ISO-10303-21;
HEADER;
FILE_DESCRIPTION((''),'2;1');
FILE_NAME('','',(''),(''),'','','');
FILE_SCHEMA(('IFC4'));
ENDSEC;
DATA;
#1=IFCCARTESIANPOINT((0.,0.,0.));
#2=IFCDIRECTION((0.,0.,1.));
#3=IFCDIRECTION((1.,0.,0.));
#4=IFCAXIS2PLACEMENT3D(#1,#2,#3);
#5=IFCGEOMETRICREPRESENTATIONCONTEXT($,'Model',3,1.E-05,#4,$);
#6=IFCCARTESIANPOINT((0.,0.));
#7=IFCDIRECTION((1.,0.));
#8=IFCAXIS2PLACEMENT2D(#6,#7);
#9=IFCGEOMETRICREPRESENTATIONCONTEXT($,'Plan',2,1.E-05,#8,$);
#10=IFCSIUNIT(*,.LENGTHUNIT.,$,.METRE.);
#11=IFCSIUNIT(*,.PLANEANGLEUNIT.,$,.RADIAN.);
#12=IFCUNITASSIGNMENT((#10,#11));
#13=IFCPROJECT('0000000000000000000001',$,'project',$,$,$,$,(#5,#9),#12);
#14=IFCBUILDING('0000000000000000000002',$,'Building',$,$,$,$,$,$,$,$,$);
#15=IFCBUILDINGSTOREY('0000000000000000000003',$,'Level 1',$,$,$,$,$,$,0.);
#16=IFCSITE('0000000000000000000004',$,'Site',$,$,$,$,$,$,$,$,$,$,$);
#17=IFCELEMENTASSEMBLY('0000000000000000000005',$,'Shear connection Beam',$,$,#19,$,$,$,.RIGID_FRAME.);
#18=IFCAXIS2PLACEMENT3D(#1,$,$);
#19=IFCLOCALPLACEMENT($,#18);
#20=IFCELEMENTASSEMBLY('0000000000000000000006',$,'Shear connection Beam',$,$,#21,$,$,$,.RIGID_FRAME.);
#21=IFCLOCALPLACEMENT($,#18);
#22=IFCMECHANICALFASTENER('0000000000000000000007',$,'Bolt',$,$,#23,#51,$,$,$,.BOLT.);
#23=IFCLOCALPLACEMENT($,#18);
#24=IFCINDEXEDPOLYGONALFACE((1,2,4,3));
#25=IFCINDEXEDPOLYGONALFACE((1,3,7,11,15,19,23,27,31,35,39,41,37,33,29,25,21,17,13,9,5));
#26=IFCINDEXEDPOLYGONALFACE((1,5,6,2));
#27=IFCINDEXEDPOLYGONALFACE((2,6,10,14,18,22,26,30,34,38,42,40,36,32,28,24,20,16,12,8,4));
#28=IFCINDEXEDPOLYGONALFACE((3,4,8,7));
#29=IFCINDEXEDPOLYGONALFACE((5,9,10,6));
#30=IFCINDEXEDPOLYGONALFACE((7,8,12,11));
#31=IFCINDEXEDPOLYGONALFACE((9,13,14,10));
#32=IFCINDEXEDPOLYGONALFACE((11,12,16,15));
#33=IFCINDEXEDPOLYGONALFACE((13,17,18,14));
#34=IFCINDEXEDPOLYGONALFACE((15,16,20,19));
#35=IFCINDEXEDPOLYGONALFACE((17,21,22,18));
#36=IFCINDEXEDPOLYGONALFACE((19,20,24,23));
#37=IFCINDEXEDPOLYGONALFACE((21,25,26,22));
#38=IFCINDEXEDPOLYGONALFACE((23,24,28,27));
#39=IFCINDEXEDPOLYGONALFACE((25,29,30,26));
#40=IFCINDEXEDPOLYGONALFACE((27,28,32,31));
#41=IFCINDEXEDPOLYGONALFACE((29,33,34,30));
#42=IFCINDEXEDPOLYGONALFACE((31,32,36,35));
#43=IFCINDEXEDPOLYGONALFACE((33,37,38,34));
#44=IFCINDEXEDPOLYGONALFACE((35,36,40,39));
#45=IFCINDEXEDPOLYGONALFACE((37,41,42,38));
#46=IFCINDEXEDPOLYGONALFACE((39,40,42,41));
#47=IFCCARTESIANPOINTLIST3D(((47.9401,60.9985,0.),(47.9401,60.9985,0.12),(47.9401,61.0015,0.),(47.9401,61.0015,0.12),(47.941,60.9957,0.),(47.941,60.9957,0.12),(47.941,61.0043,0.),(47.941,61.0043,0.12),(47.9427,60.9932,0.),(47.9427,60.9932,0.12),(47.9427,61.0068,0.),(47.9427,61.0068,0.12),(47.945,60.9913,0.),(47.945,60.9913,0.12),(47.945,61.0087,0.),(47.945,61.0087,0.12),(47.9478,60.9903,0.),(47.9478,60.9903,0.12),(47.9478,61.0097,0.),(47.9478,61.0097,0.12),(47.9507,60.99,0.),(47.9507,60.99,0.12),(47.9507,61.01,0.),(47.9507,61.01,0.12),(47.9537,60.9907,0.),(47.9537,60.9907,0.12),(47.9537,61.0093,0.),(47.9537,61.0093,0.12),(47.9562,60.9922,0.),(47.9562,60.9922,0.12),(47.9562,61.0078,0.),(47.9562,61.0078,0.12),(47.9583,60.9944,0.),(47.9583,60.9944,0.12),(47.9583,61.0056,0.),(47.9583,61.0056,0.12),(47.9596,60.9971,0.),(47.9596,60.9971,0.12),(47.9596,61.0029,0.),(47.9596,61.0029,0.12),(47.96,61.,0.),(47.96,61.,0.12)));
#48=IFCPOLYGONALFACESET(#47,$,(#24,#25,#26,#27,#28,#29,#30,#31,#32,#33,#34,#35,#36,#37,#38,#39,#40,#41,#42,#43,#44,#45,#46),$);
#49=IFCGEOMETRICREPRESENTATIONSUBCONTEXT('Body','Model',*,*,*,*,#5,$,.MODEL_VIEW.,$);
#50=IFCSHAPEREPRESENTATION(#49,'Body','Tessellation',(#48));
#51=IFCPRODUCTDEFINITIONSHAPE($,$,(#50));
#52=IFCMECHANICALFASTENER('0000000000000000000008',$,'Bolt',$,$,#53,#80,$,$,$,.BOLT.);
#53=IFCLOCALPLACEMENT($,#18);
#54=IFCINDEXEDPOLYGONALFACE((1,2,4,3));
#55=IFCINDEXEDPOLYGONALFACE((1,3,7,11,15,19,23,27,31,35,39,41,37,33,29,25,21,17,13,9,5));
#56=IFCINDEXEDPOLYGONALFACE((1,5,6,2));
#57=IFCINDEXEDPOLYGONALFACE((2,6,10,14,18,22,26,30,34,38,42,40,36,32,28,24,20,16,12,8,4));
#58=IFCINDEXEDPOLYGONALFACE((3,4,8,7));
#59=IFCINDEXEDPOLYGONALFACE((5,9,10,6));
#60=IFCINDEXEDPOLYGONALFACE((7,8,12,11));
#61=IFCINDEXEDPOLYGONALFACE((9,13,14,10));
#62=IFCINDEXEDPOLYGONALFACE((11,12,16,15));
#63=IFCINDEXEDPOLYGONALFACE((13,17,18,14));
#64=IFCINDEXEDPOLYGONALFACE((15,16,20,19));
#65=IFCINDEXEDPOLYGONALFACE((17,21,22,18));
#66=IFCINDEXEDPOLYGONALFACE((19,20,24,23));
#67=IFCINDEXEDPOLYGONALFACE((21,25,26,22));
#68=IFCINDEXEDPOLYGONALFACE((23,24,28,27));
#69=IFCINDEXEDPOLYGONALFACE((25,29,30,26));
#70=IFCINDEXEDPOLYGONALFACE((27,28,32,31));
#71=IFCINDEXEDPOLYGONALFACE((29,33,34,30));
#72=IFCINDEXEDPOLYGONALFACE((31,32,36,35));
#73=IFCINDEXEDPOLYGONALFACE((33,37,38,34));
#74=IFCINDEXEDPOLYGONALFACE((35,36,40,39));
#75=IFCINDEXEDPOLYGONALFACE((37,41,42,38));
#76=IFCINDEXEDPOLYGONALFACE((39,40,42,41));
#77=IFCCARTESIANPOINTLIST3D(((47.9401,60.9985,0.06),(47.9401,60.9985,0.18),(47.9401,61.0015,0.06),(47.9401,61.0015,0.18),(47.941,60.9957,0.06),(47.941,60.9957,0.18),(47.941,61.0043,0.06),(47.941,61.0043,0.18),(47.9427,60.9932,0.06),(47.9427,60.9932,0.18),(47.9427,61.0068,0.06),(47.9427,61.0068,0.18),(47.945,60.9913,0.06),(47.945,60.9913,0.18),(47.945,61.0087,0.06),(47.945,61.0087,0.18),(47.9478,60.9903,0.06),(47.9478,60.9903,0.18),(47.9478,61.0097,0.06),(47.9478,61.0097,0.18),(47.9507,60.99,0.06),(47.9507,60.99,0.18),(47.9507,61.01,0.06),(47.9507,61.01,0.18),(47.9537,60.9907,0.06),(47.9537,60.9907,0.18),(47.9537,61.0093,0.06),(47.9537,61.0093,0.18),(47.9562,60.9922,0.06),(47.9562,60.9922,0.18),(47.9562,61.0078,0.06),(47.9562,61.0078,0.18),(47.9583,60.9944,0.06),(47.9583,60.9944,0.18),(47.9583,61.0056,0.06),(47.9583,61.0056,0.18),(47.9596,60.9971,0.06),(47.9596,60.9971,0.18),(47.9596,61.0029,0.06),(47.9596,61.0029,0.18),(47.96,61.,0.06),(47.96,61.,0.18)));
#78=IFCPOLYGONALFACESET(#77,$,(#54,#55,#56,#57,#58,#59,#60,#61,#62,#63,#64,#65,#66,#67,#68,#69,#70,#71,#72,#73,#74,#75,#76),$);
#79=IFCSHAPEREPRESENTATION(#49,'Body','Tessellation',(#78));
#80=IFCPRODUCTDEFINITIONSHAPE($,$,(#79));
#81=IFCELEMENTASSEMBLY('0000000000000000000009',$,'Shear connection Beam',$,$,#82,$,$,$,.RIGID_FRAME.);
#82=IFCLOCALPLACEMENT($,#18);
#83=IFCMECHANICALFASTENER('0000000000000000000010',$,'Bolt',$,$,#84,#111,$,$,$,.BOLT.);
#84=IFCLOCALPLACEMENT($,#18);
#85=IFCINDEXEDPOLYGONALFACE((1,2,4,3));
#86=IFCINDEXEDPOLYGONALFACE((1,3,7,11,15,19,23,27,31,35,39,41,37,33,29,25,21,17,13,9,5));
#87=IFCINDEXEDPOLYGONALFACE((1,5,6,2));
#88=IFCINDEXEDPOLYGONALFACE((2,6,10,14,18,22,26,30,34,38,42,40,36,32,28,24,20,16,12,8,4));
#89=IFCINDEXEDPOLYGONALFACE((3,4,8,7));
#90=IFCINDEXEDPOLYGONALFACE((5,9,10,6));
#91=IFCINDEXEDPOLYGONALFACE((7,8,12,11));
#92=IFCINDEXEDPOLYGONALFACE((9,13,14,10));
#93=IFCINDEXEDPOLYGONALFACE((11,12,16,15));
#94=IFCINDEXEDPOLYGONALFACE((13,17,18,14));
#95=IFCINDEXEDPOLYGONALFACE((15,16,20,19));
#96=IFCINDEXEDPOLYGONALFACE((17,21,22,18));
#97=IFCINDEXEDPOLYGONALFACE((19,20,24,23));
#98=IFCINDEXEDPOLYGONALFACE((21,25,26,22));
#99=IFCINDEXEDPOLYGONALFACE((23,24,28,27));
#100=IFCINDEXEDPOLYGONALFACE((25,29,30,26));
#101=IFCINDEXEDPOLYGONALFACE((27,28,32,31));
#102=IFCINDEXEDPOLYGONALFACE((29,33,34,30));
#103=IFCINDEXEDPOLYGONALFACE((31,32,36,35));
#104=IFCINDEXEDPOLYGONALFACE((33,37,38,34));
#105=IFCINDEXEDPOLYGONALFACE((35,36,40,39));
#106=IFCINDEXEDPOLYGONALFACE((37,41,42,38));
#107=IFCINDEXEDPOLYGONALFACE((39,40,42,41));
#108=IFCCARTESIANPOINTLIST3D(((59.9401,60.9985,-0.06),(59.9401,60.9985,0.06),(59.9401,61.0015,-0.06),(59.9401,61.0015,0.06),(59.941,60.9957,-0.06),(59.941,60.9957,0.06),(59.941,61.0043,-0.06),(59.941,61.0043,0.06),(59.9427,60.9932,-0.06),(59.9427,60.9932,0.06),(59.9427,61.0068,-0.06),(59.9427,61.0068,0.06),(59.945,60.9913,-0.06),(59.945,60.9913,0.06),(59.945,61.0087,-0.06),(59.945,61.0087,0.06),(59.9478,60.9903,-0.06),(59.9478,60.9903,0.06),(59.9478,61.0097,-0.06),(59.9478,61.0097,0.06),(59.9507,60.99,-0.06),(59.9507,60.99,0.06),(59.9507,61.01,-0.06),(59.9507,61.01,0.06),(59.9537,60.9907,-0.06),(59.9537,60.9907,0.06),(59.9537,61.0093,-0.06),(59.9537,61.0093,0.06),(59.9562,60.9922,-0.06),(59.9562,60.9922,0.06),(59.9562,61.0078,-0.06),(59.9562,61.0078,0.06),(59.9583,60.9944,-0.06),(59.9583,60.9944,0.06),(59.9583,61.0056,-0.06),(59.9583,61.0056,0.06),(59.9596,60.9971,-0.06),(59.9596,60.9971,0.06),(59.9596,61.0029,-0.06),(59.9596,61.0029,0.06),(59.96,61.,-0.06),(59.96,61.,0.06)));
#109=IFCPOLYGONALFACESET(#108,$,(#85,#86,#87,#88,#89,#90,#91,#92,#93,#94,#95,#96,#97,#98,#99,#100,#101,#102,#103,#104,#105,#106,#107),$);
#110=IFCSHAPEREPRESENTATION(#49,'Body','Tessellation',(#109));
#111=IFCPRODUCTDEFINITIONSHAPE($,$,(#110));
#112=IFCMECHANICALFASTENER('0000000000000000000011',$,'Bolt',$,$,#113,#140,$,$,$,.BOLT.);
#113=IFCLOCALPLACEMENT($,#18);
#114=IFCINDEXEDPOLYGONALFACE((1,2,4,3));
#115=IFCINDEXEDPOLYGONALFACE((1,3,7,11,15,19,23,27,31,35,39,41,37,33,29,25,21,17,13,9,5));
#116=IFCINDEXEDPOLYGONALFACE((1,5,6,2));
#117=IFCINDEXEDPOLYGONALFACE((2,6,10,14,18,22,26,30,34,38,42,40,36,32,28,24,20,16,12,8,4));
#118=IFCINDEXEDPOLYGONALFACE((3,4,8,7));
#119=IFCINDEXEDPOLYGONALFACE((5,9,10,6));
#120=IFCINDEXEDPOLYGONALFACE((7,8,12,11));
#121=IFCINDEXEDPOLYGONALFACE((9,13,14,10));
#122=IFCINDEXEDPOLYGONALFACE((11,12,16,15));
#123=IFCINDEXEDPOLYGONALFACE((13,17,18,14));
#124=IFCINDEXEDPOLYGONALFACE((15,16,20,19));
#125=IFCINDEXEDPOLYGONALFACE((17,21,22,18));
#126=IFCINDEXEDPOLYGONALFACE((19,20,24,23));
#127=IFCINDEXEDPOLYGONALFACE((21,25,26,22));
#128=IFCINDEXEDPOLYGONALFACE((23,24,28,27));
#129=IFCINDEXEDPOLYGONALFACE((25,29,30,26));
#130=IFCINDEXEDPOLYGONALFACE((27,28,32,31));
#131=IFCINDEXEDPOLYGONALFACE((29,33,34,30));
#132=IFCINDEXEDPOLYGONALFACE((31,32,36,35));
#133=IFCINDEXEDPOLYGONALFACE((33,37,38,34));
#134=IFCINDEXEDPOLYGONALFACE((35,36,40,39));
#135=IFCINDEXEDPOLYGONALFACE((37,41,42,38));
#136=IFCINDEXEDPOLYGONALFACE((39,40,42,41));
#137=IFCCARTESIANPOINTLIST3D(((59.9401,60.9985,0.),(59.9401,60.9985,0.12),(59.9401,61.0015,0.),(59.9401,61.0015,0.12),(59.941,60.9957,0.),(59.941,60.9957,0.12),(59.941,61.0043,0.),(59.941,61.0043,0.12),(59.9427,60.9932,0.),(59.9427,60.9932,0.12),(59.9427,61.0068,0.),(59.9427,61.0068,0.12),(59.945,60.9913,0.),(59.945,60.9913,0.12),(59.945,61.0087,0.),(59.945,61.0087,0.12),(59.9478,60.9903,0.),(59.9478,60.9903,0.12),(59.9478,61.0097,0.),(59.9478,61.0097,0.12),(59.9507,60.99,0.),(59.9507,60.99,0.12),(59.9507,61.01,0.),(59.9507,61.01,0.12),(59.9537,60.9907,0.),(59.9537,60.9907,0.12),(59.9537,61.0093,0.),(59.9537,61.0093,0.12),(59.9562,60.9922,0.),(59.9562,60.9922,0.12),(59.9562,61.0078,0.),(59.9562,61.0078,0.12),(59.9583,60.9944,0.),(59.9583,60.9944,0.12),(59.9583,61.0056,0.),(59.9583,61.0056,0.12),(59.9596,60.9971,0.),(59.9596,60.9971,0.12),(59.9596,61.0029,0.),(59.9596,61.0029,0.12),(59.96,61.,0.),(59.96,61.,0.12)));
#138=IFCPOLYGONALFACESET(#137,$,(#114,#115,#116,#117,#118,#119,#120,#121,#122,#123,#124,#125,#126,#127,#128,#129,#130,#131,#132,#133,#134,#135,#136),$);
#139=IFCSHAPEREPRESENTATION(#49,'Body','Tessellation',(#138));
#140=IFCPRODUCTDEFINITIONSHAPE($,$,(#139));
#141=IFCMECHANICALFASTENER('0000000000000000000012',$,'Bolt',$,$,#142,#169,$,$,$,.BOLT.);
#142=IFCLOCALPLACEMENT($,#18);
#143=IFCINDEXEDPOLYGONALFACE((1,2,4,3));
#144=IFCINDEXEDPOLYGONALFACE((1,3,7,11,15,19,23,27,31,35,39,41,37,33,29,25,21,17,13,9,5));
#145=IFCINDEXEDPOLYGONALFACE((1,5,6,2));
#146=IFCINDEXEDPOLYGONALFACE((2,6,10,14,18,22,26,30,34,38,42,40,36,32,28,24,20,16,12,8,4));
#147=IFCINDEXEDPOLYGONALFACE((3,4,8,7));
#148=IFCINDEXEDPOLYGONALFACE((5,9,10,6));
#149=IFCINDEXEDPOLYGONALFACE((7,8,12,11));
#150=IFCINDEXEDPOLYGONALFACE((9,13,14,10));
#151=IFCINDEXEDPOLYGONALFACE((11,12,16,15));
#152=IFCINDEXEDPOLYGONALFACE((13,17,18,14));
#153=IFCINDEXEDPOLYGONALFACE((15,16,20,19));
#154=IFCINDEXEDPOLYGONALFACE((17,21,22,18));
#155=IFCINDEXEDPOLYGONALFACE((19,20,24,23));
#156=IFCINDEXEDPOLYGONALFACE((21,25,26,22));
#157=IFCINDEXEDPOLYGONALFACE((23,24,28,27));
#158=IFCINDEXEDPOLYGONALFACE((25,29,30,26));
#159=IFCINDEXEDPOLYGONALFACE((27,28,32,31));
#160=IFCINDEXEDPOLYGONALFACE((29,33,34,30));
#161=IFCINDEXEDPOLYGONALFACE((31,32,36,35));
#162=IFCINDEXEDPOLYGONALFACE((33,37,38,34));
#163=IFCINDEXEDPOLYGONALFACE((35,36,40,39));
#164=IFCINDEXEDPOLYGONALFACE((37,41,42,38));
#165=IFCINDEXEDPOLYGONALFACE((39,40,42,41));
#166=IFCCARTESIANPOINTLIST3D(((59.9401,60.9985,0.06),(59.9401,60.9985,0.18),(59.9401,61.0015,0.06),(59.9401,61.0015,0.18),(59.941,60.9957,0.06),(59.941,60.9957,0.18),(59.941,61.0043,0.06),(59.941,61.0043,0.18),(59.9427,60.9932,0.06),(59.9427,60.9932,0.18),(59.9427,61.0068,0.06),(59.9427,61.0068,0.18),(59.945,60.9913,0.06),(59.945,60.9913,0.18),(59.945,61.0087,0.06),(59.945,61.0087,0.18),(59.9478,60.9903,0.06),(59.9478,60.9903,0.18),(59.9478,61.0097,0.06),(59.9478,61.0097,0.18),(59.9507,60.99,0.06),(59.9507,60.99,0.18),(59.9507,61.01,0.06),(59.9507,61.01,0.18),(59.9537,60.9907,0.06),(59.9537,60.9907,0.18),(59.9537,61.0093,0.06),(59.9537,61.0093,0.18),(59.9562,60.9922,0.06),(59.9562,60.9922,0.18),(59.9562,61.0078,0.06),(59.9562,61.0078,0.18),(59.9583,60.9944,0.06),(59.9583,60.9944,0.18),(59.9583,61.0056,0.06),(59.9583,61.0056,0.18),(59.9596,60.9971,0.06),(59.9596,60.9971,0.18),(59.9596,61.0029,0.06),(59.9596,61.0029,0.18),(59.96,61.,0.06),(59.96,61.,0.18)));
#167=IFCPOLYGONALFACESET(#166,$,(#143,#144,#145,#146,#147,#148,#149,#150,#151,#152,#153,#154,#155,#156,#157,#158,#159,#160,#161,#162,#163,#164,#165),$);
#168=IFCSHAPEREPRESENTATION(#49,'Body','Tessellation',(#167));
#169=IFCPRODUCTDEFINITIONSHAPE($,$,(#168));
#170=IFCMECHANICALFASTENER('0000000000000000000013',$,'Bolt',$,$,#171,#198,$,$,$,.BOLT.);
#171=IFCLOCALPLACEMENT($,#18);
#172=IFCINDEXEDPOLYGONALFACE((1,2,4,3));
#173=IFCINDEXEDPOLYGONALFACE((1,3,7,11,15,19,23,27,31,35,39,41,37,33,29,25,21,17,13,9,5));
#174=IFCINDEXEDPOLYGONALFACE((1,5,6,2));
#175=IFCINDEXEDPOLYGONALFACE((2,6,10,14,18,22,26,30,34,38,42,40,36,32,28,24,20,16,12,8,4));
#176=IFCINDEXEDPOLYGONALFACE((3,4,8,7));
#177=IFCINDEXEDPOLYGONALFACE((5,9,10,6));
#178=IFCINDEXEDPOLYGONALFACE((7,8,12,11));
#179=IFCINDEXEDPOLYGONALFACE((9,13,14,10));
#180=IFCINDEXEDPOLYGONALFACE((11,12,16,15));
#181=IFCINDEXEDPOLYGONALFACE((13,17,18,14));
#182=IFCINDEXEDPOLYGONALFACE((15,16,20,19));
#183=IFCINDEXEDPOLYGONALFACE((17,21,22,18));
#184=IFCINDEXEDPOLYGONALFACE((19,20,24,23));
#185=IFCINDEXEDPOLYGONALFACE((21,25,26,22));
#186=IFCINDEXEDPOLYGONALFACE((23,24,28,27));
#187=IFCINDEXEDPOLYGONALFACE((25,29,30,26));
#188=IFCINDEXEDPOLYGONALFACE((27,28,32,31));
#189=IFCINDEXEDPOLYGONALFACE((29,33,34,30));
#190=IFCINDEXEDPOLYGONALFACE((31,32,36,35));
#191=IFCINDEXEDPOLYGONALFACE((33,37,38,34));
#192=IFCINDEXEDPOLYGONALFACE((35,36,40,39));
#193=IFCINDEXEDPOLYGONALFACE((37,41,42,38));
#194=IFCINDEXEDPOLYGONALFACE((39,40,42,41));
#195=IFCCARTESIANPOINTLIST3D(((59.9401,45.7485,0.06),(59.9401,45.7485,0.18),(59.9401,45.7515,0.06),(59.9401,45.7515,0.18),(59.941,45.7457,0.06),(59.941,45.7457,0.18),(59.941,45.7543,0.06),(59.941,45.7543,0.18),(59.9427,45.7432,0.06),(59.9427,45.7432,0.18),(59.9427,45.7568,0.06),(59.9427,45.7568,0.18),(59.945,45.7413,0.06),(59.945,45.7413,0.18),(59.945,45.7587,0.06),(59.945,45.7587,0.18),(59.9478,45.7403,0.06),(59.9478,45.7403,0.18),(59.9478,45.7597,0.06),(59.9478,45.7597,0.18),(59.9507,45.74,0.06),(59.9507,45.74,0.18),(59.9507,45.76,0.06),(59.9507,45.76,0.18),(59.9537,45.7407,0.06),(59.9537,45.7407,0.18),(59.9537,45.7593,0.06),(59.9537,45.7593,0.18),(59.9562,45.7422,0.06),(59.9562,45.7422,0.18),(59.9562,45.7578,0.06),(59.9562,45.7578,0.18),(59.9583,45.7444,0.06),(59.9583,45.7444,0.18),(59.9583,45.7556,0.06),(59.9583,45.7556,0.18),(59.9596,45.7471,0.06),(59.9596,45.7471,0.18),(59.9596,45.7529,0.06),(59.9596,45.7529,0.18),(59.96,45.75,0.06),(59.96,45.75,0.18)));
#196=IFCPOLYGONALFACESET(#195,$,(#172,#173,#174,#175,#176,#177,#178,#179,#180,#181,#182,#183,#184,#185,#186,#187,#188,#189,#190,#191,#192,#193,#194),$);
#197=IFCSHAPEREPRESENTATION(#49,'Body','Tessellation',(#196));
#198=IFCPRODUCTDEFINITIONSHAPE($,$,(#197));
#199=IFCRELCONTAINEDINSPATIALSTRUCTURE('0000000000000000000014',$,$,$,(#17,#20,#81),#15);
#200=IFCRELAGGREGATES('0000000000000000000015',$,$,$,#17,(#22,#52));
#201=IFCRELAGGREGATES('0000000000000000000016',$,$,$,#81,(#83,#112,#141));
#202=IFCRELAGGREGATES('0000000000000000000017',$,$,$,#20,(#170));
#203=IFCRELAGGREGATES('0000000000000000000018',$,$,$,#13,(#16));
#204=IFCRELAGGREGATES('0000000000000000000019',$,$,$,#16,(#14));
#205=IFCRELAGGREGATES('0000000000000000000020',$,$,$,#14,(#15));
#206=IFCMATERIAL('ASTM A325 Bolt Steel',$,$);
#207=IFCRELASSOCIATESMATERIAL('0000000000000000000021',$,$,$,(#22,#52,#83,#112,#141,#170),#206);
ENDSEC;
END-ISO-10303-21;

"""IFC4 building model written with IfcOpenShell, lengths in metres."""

from ifc_helpers import new_model, si_unit, frame, origin_with_axes, origin_2d, origin_2d_with_axis, place, context, subcontext, project, spatial, circle, extrude, material, element, aggregate, save


model = new_model("IFC4")

# Units and contexts
model_context = context("Model", 3, precision=1e-05, world=origin_with_axes())
plan_context = context("Plan", 2, precision=1e-05, world=origin_2d_with_axis())
body_context = subcontext(model_context, "Body", "Model", "MODEL_VIEW")
ifc_project = project(units=[si_unit("LENGTHUNIT", "METRE"), si_unit("PLANEANGLEUNIT", "RADIAN")], contexts=[model_context, plan_context])

# Site, building, storey
site = spatial("IfcSite", under=ifc_project, Name="Site")
building = spatial("IfcBuilding", under=site, Name="Building")
storey = spatial("IfcBuildingStorey", under=building, Name="Level 1", Elevation=0.0)

# Element assemblies
assembly_1 = element("IfcElementAssembly", 1, inside=storey, Name="Shear connection Beam", PredefinedType="RIGID_FRAME")
assembly_2 = element("IfcElementAssembly", 2, inside=storey, Name="Shear connection Beam", PredefinedType="RIGID_FRAME")

# Shared definitions
ifc_material_1 = material(Name="ASTM A325 Bolt Steel")

# Mechanical fasteners
mechanical_fastener_1_placement = place(None, frame((47.95, 61.0, 0.0), z_axis=(0.0, 0.0, 1.0), x_axis=(1.0, 0.0, 0.0)))
mechanical_fastener_1 = element("IfcMechanicalFastener", 3, at=mechanical_fastener_1_placement, material=ifc_material_1, Name="Bolt", PredefinedType="BOLT", context=body_context, shape_type="SweptSolid", body=[
    extrude(circle(Radius=0.01, at=origin_2d()), origin_with_axes(), (0.0, 0.0, 1.0), 0.12),
])
mechanical_fastener_2_placement = place(None, frame((47.95, 61.0, 0.06), z_axis=(0.0, 0.0, 1.0), x_axis=(1.0, 0.0, 0.0)))
mechanical_fastener_2 = element("IfcMechanicalFastener", 4, at=mechanical_fastener_2_placement, material=ifc_material_1, Name="Bolt", PredefinedType="BOLT", context=body_context, shape_type="SweptSolid", body=[
    extrude(circle(Radius=0.01, at=origin_2d()), origin_with_axes(), (0.0, 0.0, 1.0), 0.12),
])
aggregate(assembly_1, [mechanical_fastener_1, mechanical_fastener_2])

# Element assembly, mechanical fasteners
assembly_3 = element("IfcElementAssembly", 5, inside=storey, Name="Shear connection Beam", PredefinedType="RIGID_FRAME")
mechanical_fastener_3_placement = place(None, frame((59.95, 61.0, -0.06), z_axis=(0.0, 0.0, 1.0), x_axis=(1.0, 0.0, 0.0)))
mechanical_fastener_3 = element("IfcMechanicalFastener", 6, at=mechanical_fastener_3_placement, material=ifc_material_1, Name="Bolt", PredefinedType="BOLT", context=body_context, shape_type="SweptSolid", body=[
    extrude(circle(Radius=0.01, at=origin_2d()), origin_with_axes(), (0.0, 0.0, 1.0), 0.12),
])
mechanical_fastener_4_placement = place(None, frame((59.95, 61.0, 0.0), z_axis=(0.0, 0.0, 1.0), x_axis=(1.0, 0.0, 0.0)))
mechanical_fastener_4 = element("IfcMechanicalFastener", 7, at=mechanical_fastener_4_placement, material=ifc_material_1, Name="Bolt", PredefinedType="BOLT", context=body_context, shape_type="SweptSolid", body=[
    extrude(circle(Radius=0.01, at=origin_2d()), origin_with_axes(), (0.0, 0.0, 1.0), 0.12),
])
mechanical_fastener_5_placement = place(None, frame((59.95, 61.0, 0.06), z_axis=(0.0, 0.0, 1.0), x_axis=(1.0, 0.0, 0.0)))
mechanical_fastener_5 = element("IfcMechanicalFastener", 8, at=mechanical_fastener_5_placement, material=ifc_material_1, Name="Bolt", PredefinedType="BOLT", context=body_context, shape_type="SweptSolid", body=[
    extrude(circle(Radius=0.01, at=origin_2d()), origin_with_axes(), (0.0, 0.0, 1.0), 0.12),
])
aggregate(assembly_3, [mechanical_fastener_3, mechanical_fastener_4, mechanical_fastener_5])

# Mechanical fastener
mechanical_fastener_6_placement = place(None, frame((59.95, 45.75, 0.06), z_axis=(0.0, 0.0, 1.0), x_axis=(1.0, 0.0, 0.0)))
mechanical_fastener_6 = element("IfcMechanicalFastener", 9, at=mechanical_fastener_6_placement, material=ifc_material_1, Name="Bolt", PredefinedType="BOLT", context=body_context, shape_type="SweptSolid", body=[
    extrude(circle(Radius=0.01, at=origin_2d()), origin_with_axes(), (0.0, 0.0, 1.0), 0.12),
])
aggregate(assembly_2, [mechanical_fastener_6])

save(model, "model.ifc")
